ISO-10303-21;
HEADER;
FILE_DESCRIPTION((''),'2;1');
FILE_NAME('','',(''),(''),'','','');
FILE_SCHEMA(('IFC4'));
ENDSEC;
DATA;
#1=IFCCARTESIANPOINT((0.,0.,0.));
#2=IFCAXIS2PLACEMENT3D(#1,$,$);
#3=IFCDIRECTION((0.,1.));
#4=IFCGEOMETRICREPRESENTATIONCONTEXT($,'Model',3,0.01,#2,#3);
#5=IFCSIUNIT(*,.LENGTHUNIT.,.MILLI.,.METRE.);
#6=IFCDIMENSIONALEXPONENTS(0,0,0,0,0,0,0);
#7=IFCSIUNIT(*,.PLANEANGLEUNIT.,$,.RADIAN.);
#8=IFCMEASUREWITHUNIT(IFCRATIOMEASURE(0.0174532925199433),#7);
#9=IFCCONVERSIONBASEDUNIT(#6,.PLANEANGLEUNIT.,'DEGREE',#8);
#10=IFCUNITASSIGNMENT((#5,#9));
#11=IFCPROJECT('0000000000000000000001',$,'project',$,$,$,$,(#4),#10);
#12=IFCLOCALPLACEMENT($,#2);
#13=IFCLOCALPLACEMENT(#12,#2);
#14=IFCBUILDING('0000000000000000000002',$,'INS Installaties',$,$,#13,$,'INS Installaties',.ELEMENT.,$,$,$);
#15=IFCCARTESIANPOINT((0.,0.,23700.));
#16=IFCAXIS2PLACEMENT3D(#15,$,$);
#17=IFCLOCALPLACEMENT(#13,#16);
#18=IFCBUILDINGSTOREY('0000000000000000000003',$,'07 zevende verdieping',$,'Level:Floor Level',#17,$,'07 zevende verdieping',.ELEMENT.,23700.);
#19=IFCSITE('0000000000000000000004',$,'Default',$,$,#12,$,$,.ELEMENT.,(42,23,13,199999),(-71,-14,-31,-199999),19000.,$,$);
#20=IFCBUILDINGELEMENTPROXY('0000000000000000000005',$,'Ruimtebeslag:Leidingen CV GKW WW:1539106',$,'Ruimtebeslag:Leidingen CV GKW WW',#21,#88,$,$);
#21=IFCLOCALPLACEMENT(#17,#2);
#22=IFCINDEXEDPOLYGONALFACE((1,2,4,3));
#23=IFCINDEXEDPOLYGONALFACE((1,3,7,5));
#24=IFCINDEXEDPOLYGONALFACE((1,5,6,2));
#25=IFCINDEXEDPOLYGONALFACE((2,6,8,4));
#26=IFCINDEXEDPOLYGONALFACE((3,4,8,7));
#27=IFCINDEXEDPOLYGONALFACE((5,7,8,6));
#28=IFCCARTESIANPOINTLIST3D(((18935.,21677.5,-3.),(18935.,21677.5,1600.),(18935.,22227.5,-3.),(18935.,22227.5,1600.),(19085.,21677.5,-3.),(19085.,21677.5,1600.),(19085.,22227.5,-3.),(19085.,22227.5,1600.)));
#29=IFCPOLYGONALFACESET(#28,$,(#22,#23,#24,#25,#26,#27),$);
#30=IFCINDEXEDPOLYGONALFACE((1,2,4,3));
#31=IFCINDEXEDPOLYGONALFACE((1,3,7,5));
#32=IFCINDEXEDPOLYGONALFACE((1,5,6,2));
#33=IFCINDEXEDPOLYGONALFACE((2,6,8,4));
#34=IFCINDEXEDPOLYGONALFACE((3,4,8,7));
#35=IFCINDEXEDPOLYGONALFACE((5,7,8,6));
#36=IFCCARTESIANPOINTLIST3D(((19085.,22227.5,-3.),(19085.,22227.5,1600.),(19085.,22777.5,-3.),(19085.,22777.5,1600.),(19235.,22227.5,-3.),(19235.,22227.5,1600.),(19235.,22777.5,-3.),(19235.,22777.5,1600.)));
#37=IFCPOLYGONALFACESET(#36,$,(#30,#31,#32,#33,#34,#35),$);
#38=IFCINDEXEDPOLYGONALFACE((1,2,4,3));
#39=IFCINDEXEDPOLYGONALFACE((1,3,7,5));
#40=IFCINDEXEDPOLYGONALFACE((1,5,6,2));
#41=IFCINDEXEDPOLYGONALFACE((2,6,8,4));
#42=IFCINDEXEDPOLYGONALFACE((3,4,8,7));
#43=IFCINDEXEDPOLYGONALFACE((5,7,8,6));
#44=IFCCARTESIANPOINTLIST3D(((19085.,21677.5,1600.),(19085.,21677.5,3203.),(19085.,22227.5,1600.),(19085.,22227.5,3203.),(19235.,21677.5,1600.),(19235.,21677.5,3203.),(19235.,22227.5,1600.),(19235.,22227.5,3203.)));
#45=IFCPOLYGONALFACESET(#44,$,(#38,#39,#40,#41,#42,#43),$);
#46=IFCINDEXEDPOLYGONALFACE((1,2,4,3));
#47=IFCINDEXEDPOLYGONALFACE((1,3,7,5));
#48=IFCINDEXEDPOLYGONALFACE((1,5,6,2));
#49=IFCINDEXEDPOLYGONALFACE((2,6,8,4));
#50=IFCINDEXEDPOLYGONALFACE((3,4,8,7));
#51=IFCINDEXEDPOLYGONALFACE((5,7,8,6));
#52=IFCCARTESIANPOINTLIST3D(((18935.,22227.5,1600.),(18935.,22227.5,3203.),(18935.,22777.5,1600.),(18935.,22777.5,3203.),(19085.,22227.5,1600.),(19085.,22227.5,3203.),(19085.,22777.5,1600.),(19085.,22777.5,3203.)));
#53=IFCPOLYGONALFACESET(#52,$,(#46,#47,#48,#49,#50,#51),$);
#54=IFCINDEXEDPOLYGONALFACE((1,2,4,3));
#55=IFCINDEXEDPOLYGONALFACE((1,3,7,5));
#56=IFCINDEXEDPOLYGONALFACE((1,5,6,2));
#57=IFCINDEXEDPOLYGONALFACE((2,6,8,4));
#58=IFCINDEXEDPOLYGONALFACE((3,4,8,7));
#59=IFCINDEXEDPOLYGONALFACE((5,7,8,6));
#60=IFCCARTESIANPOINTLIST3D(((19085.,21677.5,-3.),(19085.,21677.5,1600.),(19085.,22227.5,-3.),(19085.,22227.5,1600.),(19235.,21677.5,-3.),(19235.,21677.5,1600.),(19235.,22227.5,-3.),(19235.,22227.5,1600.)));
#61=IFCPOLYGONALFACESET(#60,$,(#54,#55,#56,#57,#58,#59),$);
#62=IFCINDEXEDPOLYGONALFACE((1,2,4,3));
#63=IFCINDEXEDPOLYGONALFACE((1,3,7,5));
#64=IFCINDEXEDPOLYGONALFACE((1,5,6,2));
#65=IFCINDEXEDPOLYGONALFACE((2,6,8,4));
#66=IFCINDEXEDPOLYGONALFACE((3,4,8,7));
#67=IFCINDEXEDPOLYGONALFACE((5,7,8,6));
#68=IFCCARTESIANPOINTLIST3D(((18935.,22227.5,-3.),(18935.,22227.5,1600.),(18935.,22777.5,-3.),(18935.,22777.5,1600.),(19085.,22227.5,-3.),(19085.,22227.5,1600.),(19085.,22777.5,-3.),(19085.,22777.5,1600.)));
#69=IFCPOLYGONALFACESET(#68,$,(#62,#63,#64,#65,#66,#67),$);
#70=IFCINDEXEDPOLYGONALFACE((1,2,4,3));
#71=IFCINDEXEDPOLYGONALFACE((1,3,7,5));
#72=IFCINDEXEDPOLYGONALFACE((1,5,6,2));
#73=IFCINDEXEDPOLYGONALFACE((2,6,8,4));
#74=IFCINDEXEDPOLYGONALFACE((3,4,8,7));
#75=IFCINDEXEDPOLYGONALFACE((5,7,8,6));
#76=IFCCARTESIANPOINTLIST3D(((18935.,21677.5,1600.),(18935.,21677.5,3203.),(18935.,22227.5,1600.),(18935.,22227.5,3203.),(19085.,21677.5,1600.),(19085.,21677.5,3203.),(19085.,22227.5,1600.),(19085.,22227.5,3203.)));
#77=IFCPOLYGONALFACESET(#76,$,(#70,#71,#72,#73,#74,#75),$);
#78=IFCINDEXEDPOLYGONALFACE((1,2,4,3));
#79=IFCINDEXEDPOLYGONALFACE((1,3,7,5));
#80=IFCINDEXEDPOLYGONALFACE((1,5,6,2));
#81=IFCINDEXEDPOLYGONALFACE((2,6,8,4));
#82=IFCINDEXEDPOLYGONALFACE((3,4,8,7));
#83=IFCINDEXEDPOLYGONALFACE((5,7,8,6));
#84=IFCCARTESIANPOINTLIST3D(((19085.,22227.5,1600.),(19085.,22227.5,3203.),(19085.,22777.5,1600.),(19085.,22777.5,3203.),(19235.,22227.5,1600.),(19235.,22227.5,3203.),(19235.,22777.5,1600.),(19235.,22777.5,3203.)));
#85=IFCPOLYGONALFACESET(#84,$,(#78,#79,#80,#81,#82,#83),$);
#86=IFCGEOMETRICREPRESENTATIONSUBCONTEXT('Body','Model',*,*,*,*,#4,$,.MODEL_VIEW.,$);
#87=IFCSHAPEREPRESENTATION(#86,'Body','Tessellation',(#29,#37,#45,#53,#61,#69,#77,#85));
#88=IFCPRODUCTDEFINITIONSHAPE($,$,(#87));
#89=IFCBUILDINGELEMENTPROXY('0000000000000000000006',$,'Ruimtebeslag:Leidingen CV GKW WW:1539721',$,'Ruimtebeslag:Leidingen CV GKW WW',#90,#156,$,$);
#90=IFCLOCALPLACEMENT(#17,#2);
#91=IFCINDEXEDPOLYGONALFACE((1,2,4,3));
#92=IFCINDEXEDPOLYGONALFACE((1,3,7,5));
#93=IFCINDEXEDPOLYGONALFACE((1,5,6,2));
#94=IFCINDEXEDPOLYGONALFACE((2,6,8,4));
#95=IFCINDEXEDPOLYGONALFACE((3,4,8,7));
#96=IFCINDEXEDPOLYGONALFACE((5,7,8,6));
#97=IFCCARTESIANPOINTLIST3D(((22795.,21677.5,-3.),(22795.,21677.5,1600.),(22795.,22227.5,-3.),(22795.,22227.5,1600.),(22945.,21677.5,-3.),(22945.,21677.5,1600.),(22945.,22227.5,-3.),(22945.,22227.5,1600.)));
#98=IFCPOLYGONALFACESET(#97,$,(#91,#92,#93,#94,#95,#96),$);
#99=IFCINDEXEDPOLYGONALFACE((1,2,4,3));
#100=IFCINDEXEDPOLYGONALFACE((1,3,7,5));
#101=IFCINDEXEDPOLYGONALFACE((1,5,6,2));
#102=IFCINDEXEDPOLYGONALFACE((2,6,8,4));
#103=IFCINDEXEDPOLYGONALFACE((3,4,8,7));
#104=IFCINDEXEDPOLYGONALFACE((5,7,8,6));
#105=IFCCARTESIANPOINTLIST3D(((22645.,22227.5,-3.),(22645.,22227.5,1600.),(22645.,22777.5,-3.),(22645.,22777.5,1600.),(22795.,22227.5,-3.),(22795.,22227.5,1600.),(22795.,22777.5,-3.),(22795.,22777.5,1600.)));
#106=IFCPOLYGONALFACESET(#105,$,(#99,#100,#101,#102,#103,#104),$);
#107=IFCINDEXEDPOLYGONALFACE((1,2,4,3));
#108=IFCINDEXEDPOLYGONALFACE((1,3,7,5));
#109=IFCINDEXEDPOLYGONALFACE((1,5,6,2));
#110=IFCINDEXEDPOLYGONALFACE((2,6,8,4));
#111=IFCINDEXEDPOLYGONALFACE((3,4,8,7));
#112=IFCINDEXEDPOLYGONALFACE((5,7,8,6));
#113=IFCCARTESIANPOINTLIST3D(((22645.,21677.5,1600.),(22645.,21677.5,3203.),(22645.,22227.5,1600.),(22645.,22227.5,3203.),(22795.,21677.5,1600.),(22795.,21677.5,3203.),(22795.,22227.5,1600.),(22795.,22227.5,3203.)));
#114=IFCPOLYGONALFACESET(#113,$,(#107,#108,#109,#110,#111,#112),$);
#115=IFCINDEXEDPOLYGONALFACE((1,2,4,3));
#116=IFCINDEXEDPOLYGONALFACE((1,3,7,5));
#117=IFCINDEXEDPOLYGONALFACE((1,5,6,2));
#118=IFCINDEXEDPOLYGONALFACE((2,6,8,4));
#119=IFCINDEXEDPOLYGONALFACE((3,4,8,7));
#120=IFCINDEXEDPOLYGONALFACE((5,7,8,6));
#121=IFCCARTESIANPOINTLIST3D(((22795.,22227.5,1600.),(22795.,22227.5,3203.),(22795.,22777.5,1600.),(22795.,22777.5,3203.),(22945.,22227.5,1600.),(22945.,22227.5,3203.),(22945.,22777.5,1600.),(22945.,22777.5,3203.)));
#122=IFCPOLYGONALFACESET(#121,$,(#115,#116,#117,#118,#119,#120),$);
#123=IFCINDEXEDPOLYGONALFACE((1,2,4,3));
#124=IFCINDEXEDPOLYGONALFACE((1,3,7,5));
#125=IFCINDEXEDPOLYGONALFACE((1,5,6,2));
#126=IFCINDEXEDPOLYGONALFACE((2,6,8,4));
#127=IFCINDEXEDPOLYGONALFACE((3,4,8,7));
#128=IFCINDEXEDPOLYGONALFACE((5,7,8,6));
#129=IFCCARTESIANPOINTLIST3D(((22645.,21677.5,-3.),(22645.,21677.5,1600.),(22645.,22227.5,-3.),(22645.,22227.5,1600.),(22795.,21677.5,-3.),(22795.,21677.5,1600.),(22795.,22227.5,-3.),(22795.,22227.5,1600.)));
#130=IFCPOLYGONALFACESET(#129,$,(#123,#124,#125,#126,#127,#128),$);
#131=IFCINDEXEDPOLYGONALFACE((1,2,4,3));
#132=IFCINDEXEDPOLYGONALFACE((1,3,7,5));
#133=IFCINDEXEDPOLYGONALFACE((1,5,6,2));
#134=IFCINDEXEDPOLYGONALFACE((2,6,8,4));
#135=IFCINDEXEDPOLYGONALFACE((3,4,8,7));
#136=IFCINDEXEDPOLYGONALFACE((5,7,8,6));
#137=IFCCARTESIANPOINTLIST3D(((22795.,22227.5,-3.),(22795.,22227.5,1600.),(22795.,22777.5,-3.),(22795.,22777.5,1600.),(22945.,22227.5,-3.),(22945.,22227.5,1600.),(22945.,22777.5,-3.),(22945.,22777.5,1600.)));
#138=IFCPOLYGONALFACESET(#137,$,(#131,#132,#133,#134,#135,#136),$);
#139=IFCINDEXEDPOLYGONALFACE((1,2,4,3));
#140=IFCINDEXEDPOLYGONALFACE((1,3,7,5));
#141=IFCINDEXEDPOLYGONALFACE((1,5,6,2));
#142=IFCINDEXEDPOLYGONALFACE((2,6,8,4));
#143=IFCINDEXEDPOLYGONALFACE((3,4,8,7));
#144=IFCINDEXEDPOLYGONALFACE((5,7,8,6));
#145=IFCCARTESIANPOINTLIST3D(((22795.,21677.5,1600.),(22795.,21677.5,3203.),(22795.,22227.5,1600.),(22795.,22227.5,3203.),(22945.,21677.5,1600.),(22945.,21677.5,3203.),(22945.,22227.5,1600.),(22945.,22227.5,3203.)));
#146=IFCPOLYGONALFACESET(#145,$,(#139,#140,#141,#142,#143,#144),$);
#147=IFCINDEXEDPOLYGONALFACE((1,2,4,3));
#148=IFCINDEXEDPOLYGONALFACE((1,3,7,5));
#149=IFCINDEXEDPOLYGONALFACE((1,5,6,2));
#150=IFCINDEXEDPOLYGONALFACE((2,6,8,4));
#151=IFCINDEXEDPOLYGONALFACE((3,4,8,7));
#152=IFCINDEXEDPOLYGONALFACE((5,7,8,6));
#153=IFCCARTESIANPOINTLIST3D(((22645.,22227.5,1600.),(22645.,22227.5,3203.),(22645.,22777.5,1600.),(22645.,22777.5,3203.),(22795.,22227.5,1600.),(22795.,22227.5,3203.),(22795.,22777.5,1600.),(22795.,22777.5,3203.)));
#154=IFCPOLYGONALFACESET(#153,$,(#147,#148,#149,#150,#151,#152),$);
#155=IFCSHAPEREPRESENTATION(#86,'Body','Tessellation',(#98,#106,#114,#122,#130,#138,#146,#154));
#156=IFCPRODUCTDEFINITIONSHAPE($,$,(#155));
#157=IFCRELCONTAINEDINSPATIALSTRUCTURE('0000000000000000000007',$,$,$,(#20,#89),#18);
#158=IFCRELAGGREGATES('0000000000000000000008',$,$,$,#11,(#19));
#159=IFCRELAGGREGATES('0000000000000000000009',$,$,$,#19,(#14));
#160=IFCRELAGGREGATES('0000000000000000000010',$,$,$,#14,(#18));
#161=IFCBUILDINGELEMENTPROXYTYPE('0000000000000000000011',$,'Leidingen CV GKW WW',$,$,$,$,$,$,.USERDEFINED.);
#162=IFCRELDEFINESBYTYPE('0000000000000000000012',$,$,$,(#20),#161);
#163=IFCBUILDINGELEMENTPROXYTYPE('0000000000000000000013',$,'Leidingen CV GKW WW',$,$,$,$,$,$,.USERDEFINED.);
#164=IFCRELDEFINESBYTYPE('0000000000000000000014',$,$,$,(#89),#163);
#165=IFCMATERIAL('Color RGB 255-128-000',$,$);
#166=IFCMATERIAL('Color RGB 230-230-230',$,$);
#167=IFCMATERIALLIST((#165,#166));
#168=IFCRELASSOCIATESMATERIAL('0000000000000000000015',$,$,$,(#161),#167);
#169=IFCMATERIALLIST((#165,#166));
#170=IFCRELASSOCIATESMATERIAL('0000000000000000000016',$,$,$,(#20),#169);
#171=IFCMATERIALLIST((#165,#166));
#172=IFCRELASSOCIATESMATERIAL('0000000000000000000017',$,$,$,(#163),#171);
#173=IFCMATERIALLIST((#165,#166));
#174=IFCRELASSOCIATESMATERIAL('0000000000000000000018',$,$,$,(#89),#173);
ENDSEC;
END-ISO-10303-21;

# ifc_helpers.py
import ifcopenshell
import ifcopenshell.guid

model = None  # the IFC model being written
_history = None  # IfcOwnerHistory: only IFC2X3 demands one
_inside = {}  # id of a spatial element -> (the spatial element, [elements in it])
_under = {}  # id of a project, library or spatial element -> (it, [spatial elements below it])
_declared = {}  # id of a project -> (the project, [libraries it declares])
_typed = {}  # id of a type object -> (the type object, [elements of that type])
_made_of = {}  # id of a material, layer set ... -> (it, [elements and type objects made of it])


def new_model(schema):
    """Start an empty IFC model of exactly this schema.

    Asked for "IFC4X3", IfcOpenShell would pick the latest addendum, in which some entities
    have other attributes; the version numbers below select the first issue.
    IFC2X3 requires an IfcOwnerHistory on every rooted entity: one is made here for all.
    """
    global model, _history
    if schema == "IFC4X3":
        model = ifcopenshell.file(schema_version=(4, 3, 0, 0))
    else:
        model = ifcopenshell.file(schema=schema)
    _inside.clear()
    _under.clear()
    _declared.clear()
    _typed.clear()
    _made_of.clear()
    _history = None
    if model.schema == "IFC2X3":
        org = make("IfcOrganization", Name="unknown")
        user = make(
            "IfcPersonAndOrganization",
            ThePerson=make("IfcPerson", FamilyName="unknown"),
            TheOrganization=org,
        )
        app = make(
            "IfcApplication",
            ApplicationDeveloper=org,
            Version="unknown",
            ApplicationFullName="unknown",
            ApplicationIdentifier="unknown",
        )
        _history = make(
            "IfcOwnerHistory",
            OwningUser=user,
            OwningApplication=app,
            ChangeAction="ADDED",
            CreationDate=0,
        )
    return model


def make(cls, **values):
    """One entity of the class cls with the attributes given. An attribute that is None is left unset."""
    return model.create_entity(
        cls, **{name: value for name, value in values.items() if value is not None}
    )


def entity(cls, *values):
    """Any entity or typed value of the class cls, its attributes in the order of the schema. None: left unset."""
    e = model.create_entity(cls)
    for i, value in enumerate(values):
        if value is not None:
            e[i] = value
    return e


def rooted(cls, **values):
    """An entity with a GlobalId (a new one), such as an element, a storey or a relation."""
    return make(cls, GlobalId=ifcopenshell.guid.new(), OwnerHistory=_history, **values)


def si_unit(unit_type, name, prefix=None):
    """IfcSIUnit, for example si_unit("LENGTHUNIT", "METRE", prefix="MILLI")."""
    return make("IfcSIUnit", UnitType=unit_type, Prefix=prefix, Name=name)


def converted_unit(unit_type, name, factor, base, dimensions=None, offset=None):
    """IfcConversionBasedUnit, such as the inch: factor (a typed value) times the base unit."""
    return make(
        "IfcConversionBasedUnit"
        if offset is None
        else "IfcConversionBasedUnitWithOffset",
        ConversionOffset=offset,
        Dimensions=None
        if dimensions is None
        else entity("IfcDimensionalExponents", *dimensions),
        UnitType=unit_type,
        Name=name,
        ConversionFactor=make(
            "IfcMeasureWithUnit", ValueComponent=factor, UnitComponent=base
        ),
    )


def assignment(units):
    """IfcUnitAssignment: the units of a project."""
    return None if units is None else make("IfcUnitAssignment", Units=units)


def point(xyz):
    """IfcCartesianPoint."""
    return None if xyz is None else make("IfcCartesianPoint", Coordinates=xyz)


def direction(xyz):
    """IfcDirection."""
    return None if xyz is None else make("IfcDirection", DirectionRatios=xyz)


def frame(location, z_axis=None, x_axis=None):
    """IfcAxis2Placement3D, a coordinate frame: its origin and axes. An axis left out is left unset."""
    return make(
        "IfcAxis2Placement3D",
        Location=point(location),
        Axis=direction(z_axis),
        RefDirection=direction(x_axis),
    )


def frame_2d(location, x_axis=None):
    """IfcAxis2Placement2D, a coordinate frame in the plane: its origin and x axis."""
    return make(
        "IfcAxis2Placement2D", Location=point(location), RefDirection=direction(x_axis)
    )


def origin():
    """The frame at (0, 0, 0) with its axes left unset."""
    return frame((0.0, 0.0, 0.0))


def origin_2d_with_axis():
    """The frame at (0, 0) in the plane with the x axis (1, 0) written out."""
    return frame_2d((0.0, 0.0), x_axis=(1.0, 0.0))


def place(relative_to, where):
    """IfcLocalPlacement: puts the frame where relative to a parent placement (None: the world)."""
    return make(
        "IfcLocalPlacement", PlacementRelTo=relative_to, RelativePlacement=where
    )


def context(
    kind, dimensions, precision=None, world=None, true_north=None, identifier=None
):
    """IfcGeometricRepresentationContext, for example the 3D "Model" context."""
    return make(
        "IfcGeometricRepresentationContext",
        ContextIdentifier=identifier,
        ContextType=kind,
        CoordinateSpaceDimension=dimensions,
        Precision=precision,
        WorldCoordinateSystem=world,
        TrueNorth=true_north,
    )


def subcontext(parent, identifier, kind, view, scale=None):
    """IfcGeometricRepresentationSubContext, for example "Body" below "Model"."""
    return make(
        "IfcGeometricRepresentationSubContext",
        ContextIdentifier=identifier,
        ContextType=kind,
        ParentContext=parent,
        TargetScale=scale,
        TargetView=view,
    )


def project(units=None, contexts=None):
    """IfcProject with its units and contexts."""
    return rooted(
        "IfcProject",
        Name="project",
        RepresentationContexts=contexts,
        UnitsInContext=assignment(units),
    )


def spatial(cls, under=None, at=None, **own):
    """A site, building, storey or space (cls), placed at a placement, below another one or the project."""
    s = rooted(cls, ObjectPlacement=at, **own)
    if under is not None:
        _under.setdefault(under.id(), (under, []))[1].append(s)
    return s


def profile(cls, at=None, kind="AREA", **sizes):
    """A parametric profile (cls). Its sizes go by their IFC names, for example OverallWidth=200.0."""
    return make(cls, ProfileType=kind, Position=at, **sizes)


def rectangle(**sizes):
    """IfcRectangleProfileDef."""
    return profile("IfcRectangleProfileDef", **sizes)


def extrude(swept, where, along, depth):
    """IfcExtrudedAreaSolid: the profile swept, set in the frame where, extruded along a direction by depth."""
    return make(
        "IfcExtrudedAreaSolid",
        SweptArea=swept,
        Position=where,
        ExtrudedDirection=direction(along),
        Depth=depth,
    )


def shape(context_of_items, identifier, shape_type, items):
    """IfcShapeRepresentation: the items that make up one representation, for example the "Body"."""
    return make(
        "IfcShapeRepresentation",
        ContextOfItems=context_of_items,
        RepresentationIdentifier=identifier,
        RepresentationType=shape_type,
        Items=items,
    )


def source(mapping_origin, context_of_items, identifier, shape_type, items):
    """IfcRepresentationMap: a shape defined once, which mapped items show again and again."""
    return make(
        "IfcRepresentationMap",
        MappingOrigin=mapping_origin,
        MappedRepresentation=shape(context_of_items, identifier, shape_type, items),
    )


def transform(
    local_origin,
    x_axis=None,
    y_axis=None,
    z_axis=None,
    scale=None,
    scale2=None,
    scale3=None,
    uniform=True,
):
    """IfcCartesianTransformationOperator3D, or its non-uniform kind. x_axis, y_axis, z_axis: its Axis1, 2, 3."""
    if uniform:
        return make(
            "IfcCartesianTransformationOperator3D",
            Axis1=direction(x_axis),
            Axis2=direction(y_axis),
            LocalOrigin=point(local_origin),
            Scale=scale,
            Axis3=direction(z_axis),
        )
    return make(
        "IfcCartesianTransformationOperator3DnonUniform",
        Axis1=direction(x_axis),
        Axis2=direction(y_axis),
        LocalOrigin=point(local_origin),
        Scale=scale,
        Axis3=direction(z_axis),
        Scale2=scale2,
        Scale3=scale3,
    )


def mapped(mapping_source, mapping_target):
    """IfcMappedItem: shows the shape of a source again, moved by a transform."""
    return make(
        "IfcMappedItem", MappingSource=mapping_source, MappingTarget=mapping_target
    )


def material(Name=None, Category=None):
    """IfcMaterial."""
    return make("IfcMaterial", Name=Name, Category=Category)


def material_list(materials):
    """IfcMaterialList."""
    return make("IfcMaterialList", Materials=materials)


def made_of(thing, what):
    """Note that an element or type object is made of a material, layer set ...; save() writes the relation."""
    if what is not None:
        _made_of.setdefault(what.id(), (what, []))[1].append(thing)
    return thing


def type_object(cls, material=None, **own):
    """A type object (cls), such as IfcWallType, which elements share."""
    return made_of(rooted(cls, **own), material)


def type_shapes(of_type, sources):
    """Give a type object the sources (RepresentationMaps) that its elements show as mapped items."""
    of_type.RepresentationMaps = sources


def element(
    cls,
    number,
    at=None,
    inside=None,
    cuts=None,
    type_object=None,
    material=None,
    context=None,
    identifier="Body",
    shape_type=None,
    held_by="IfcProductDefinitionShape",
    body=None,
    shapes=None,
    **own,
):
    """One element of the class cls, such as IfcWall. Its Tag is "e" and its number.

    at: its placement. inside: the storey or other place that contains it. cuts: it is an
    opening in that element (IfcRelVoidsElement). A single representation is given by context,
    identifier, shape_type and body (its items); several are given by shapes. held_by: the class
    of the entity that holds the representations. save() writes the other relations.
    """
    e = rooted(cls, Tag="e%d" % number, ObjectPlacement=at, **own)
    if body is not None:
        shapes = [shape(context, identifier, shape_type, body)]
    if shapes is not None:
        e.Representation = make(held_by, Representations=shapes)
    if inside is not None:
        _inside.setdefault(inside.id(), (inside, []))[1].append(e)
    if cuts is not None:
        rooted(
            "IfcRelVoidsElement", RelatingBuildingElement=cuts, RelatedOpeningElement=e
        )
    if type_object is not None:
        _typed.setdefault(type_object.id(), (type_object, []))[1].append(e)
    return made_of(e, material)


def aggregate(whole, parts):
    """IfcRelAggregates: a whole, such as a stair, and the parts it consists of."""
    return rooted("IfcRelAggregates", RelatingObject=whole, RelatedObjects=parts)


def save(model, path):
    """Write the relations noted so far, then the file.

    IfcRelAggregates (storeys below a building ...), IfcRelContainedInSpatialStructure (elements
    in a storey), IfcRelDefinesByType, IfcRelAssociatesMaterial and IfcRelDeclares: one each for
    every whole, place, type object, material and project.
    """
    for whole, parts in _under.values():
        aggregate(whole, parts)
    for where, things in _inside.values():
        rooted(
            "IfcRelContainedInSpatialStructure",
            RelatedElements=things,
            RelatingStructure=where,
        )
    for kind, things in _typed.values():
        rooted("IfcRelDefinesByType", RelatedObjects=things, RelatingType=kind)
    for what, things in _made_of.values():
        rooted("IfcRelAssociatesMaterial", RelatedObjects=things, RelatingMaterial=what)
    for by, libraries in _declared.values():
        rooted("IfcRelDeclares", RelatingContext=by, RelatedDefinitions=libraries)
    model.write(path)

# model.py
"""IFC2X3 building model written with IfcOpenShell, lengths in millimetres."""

from ifc_helpers import new_model, entity, si_unit, converted_unit, direction, frame, frame_2d, origin, origin_2d_with_axis, place, context, subcontext, project, spatial, rectangle, extrude, source, transform, mapped, material, material_list, type_object, type_shapes, element, save


model = new_model("IFC2X3")

# Units and contexts
model_context = context("Model", 3, precision=0.01, world=origin(), true_north=direction((0.0, 1.0)))
body_context = subcontext(model_context, "Body", "Model", "MODEL_VIEW")
ifc_project = project(units=[si_unit("LENGTHUNIT", "METRE", prefix="MILLI"), converted_unit("PLANEANGLEUNIT", "DEGREE", entity("IfcRatioMeasure", 0.0174532925199433), si_unit("PLANEANGLEUNIT", "RADIAN"), dimensions=[0, 0, 0, 0, 0, 0, 0])], contexts=[model_context])

# Site, building, storey
site_placement = place(None, origin())
site = spatial("IfcSite", under=ifc_project, at=site_placement, Name="Default", CompositionType="ELEMENT", RefLatitude=(42, 23, 13, 199999), RefLongitude=(-71, -14, -31, -199999), RefElevation=19000.0)
building_placement = place(site_placement, origin())
building = spatial("IfcBuilding", under=site, at=building_placement, Name="INS Installaties", LongName="INS Installaties", CompositionType="ELEMENT")
storey_placement = place(building_placement, frame((0.0, 0.0, 23700.0)))
storey = spatial("IfcBuildingStorey", under=building, at=storey_placement, Name="07 zevende verdieping", ObjectType="Level:Floor Level", LongName="07 zevende verdieping", CompositionType="ELEMENT", Elevation=23700.0)

# Building element proxies
ifc_material_1 = material(Name="Color RGB 255-128-000")
ifc_material_2 = material(Name="Color RGB 230-230-230")
ifc_material_list_1 = material_list([ifc_material_1, ifc_material_2])
ifc_material_list_2 = material_list([ifc_material_1, ifc_material_2])
building_element_proxy_type_1 = type_object("IfcBuildingElementProxyType", Name="Leidingen CV GKW WW", PredefinedType="USERDEFINED", material=ifc_material_list_2)
shared_shape_1 = source(origin(), body_context, "Body", "SweptSolid", [
    extrude(rectangle(XDim=550.0, YDim=150.0, at=frame_2d((0.0, 0.0), x_axis=(1.0, 0.0))), frame((75.0, 275.0, -3203.0), z_axis=(0.0, 0.0, 1.0), x_axis=(0.0, -1.0, 0.0)), (0.0, 0.0, 1.0), 1603.0),
    extrude(rectangle(XDim=550.0, YDim=150.0, at=origin_2d_with_axis()), frame((-75.0, -275.0, -3203.0), z_axis=(0.0, 0.0, 1.0), x_axis=(0.0, 1.0, 0.0)), (0.0, 0.0, 1.0), 1603.0),
    extrude(rectangle(XDim=150.0, YDim=550.0, at=frame_2d((0.0, 0.0), x_axis=(1.0, 0.0))), frame((-75.0, 275.0, -1600.0), z_axis=(0.0, 0.0, 1.0), x_axis=(-1.0, 0.0, 0.0)), (0.0, 0.0, 1.0), 1603.0),
    extrude(rectangle(XDim=150.0, YDim=550.0, at=frame_2d((0.0, 0.0), x_axis=(1.0, 0.0))), frame((75.0, -275.0, -1600.0)), (0.0, 0.0, 1.0), 1603.0),
    extrude(rectangle(XDim=150.0, YDim=550.0, at=origin_2d_with_axis()), frame((-75.0, 275.0, -3203.0), z_axis=(0.0, 0.0, 1.0), x_axis=(-1.0, 0.0, 0.0)), (0.0, 0.0, 1.0), 1603.0),
    extrude(rectangle(XDim=150.0, YDim=550.0, at=origin_2d_with_axis()), frame((75.0, -275.0, -3203.0)), (0.0, 0.0, 1.0), 1603.0),
    extrude(rectangle(XDim=550.0, YDim=150.0, at=origin_2d_with_axis()), frame((75.0, 275.0, -1600.0), z_axis=(0.0, 0.0, 1.0), x_axis=(0.0, -1.0, 0.0)), (0.0, 0.0, 1.0), 1603.0),
    extrude(rectangle(XDim=550.0, YDim=150.0, at=origin_2d_with_axis()), frame((-75.0, -275.0, -1600.0), z_axis=(0.0, 0.0, 1.0), x_axis=(0.0, 1.0, 0.0)), (0.0, 0.0, 1.0), 1603.0),
])
type_shapes(building_element_proxy_type_1, [shared_shape_1])
proxy_1_placement = place(storey_placement, frame((19085.0, 22227.5, 3200.0), z_axis=(0.0, 0.0, 1.0), x_axis=(-1.0, 0.0, 0.0)))
element("IfcBuildingElementProxy", 1, at=proxy_1_placement, inside=storey, type_object=building_element_proxy_type_1, material=ifc_material_list_1, Name="Ruimtebeslag:Leidingen CV GKW WW:1539106", ObjectType="Ruimtebeslag:Leidingen CV GKW WW", context=body_context, shape_type="MappedRepresentation", body=[
    mapped(shared_shape_1, transform((0.0, 0.0, 0.0), scale=1.0)),
])
ifc_material_list_3 = material_list([ifc_material_1, ifc_material_2])
ifc_material_list_4 = material_list([ifc_material_1, ifc_material_2])
building_element_proxy_type_2 = type_object("IfcBuildingElementProxyType", Name="Leidingen CV GKW WW", PredefinedType="USERDEFINED", material=ifc_material_list_4)
shared_shape_2 = source(origin(), body_context, "Body", "SweptSolid", [
    extrude(rectangle(XDim=150.0, YDim=550.0, at=frame_2d((0.0, 0.0), x_axis=(1.0, 0.0))), frame((75.0, -275.0, -3203.0)), (0.0, 0.0, 1.0), 1603.0),
    extrude(rectangle(XDim=150.0, YDim=550.0, at=origin_2d_with_axis()), frame((-75.0, 275.0, -3203.0), z_axis=(0.0, 0.0, 1.0), x_axis=(-1.0, 0.0, 0.0)), (0.0, 0.0, 1.0), 1603.0),
    extrude(rectangle(XDim=550.0, YDim=150.0, at=frame_2d((0.0, 0.0), x_axis=(1.0, 0.0))), frame((-75.0, -275.0, -1600.0), z_axis=(0.0, 0.0, 1.0), x_axis=(0.0, 1.0, 0.0)), (0.0, 0.0, 1.0), 1603.0),
    extrude(rectangle(XDim=550.0, YDim=150.0, at=origin_2d_with_axis()), frame((75.0, 275.0, -1600.0), z_axis=(0.0, 0.0, 1.0), x_axis=(0.0, -1.0, 0.0)), (0.0, 0.0, 1.0), 1603.0),
    extrude(rectangle(XDim=550.0, YDim=150.0, at=origin_2d_with_axis()), frame((-75.0, -275.0, -3203.0), z_axis=(0.0, 0.0, 1.0), x_axis=(0.0, 1.0, 0.0)), (0.0, 0.0, 1.0), 1603.0),
    extrude(rectangle(XDim=550.0, YDim=150.0, at=origin_2d_with_axis()), frame((75.0, 275.0, -3203.0), z_axis=(0.0, 0.0, 1.0), x_axis=(0.0, -1.0, 0.0)), (0.0, 0.0, 1.0), 1603.0),
    extrude(rectangle(XDim=150.0, YDim=550.0, at=frame_2d((0.0, 0.0), x_axis=(1.0, 0.0))), frame((75.0, -275.0, -1600.0)), (0.0, 0.0, 1.0), 1603.0),
    extrude(rectangle(XDim=150.0, YDim=550.0, at=origin_2d_with_axis()), frame((-75.0, 275.0, -1600.0), z_axis=(0.0, 0.0, 1.0), x_axis=(-1.0, 0.0, 0.0)), (0.0, 0.0, 1.0), 1603.0),
])
type_shapes(building_element_proxy_type_2, [shared_shape_2])
proxy_2_placement = place(storey_placement, frame((22795.0, 22227.5, 3200.0)))
element("IfcBuildingElementProxy", 2, at=proxy_2_placement, inside=storey, type_object=building_element_proxy_type_2, material=ifc_material_list_3, Name="Ruimtebeslag:Leidingen CV GKW WW:1539721", ObjectType="Ruimtebeslag:Leidingen CV GKW WW", context=body_context, shape_type="MappedRepresentation", body=[
    mapped(shared_shape_2, transform((0.0, 0.0, 0.0), scale=1.0)),
])

save(model, "model.ifc")
